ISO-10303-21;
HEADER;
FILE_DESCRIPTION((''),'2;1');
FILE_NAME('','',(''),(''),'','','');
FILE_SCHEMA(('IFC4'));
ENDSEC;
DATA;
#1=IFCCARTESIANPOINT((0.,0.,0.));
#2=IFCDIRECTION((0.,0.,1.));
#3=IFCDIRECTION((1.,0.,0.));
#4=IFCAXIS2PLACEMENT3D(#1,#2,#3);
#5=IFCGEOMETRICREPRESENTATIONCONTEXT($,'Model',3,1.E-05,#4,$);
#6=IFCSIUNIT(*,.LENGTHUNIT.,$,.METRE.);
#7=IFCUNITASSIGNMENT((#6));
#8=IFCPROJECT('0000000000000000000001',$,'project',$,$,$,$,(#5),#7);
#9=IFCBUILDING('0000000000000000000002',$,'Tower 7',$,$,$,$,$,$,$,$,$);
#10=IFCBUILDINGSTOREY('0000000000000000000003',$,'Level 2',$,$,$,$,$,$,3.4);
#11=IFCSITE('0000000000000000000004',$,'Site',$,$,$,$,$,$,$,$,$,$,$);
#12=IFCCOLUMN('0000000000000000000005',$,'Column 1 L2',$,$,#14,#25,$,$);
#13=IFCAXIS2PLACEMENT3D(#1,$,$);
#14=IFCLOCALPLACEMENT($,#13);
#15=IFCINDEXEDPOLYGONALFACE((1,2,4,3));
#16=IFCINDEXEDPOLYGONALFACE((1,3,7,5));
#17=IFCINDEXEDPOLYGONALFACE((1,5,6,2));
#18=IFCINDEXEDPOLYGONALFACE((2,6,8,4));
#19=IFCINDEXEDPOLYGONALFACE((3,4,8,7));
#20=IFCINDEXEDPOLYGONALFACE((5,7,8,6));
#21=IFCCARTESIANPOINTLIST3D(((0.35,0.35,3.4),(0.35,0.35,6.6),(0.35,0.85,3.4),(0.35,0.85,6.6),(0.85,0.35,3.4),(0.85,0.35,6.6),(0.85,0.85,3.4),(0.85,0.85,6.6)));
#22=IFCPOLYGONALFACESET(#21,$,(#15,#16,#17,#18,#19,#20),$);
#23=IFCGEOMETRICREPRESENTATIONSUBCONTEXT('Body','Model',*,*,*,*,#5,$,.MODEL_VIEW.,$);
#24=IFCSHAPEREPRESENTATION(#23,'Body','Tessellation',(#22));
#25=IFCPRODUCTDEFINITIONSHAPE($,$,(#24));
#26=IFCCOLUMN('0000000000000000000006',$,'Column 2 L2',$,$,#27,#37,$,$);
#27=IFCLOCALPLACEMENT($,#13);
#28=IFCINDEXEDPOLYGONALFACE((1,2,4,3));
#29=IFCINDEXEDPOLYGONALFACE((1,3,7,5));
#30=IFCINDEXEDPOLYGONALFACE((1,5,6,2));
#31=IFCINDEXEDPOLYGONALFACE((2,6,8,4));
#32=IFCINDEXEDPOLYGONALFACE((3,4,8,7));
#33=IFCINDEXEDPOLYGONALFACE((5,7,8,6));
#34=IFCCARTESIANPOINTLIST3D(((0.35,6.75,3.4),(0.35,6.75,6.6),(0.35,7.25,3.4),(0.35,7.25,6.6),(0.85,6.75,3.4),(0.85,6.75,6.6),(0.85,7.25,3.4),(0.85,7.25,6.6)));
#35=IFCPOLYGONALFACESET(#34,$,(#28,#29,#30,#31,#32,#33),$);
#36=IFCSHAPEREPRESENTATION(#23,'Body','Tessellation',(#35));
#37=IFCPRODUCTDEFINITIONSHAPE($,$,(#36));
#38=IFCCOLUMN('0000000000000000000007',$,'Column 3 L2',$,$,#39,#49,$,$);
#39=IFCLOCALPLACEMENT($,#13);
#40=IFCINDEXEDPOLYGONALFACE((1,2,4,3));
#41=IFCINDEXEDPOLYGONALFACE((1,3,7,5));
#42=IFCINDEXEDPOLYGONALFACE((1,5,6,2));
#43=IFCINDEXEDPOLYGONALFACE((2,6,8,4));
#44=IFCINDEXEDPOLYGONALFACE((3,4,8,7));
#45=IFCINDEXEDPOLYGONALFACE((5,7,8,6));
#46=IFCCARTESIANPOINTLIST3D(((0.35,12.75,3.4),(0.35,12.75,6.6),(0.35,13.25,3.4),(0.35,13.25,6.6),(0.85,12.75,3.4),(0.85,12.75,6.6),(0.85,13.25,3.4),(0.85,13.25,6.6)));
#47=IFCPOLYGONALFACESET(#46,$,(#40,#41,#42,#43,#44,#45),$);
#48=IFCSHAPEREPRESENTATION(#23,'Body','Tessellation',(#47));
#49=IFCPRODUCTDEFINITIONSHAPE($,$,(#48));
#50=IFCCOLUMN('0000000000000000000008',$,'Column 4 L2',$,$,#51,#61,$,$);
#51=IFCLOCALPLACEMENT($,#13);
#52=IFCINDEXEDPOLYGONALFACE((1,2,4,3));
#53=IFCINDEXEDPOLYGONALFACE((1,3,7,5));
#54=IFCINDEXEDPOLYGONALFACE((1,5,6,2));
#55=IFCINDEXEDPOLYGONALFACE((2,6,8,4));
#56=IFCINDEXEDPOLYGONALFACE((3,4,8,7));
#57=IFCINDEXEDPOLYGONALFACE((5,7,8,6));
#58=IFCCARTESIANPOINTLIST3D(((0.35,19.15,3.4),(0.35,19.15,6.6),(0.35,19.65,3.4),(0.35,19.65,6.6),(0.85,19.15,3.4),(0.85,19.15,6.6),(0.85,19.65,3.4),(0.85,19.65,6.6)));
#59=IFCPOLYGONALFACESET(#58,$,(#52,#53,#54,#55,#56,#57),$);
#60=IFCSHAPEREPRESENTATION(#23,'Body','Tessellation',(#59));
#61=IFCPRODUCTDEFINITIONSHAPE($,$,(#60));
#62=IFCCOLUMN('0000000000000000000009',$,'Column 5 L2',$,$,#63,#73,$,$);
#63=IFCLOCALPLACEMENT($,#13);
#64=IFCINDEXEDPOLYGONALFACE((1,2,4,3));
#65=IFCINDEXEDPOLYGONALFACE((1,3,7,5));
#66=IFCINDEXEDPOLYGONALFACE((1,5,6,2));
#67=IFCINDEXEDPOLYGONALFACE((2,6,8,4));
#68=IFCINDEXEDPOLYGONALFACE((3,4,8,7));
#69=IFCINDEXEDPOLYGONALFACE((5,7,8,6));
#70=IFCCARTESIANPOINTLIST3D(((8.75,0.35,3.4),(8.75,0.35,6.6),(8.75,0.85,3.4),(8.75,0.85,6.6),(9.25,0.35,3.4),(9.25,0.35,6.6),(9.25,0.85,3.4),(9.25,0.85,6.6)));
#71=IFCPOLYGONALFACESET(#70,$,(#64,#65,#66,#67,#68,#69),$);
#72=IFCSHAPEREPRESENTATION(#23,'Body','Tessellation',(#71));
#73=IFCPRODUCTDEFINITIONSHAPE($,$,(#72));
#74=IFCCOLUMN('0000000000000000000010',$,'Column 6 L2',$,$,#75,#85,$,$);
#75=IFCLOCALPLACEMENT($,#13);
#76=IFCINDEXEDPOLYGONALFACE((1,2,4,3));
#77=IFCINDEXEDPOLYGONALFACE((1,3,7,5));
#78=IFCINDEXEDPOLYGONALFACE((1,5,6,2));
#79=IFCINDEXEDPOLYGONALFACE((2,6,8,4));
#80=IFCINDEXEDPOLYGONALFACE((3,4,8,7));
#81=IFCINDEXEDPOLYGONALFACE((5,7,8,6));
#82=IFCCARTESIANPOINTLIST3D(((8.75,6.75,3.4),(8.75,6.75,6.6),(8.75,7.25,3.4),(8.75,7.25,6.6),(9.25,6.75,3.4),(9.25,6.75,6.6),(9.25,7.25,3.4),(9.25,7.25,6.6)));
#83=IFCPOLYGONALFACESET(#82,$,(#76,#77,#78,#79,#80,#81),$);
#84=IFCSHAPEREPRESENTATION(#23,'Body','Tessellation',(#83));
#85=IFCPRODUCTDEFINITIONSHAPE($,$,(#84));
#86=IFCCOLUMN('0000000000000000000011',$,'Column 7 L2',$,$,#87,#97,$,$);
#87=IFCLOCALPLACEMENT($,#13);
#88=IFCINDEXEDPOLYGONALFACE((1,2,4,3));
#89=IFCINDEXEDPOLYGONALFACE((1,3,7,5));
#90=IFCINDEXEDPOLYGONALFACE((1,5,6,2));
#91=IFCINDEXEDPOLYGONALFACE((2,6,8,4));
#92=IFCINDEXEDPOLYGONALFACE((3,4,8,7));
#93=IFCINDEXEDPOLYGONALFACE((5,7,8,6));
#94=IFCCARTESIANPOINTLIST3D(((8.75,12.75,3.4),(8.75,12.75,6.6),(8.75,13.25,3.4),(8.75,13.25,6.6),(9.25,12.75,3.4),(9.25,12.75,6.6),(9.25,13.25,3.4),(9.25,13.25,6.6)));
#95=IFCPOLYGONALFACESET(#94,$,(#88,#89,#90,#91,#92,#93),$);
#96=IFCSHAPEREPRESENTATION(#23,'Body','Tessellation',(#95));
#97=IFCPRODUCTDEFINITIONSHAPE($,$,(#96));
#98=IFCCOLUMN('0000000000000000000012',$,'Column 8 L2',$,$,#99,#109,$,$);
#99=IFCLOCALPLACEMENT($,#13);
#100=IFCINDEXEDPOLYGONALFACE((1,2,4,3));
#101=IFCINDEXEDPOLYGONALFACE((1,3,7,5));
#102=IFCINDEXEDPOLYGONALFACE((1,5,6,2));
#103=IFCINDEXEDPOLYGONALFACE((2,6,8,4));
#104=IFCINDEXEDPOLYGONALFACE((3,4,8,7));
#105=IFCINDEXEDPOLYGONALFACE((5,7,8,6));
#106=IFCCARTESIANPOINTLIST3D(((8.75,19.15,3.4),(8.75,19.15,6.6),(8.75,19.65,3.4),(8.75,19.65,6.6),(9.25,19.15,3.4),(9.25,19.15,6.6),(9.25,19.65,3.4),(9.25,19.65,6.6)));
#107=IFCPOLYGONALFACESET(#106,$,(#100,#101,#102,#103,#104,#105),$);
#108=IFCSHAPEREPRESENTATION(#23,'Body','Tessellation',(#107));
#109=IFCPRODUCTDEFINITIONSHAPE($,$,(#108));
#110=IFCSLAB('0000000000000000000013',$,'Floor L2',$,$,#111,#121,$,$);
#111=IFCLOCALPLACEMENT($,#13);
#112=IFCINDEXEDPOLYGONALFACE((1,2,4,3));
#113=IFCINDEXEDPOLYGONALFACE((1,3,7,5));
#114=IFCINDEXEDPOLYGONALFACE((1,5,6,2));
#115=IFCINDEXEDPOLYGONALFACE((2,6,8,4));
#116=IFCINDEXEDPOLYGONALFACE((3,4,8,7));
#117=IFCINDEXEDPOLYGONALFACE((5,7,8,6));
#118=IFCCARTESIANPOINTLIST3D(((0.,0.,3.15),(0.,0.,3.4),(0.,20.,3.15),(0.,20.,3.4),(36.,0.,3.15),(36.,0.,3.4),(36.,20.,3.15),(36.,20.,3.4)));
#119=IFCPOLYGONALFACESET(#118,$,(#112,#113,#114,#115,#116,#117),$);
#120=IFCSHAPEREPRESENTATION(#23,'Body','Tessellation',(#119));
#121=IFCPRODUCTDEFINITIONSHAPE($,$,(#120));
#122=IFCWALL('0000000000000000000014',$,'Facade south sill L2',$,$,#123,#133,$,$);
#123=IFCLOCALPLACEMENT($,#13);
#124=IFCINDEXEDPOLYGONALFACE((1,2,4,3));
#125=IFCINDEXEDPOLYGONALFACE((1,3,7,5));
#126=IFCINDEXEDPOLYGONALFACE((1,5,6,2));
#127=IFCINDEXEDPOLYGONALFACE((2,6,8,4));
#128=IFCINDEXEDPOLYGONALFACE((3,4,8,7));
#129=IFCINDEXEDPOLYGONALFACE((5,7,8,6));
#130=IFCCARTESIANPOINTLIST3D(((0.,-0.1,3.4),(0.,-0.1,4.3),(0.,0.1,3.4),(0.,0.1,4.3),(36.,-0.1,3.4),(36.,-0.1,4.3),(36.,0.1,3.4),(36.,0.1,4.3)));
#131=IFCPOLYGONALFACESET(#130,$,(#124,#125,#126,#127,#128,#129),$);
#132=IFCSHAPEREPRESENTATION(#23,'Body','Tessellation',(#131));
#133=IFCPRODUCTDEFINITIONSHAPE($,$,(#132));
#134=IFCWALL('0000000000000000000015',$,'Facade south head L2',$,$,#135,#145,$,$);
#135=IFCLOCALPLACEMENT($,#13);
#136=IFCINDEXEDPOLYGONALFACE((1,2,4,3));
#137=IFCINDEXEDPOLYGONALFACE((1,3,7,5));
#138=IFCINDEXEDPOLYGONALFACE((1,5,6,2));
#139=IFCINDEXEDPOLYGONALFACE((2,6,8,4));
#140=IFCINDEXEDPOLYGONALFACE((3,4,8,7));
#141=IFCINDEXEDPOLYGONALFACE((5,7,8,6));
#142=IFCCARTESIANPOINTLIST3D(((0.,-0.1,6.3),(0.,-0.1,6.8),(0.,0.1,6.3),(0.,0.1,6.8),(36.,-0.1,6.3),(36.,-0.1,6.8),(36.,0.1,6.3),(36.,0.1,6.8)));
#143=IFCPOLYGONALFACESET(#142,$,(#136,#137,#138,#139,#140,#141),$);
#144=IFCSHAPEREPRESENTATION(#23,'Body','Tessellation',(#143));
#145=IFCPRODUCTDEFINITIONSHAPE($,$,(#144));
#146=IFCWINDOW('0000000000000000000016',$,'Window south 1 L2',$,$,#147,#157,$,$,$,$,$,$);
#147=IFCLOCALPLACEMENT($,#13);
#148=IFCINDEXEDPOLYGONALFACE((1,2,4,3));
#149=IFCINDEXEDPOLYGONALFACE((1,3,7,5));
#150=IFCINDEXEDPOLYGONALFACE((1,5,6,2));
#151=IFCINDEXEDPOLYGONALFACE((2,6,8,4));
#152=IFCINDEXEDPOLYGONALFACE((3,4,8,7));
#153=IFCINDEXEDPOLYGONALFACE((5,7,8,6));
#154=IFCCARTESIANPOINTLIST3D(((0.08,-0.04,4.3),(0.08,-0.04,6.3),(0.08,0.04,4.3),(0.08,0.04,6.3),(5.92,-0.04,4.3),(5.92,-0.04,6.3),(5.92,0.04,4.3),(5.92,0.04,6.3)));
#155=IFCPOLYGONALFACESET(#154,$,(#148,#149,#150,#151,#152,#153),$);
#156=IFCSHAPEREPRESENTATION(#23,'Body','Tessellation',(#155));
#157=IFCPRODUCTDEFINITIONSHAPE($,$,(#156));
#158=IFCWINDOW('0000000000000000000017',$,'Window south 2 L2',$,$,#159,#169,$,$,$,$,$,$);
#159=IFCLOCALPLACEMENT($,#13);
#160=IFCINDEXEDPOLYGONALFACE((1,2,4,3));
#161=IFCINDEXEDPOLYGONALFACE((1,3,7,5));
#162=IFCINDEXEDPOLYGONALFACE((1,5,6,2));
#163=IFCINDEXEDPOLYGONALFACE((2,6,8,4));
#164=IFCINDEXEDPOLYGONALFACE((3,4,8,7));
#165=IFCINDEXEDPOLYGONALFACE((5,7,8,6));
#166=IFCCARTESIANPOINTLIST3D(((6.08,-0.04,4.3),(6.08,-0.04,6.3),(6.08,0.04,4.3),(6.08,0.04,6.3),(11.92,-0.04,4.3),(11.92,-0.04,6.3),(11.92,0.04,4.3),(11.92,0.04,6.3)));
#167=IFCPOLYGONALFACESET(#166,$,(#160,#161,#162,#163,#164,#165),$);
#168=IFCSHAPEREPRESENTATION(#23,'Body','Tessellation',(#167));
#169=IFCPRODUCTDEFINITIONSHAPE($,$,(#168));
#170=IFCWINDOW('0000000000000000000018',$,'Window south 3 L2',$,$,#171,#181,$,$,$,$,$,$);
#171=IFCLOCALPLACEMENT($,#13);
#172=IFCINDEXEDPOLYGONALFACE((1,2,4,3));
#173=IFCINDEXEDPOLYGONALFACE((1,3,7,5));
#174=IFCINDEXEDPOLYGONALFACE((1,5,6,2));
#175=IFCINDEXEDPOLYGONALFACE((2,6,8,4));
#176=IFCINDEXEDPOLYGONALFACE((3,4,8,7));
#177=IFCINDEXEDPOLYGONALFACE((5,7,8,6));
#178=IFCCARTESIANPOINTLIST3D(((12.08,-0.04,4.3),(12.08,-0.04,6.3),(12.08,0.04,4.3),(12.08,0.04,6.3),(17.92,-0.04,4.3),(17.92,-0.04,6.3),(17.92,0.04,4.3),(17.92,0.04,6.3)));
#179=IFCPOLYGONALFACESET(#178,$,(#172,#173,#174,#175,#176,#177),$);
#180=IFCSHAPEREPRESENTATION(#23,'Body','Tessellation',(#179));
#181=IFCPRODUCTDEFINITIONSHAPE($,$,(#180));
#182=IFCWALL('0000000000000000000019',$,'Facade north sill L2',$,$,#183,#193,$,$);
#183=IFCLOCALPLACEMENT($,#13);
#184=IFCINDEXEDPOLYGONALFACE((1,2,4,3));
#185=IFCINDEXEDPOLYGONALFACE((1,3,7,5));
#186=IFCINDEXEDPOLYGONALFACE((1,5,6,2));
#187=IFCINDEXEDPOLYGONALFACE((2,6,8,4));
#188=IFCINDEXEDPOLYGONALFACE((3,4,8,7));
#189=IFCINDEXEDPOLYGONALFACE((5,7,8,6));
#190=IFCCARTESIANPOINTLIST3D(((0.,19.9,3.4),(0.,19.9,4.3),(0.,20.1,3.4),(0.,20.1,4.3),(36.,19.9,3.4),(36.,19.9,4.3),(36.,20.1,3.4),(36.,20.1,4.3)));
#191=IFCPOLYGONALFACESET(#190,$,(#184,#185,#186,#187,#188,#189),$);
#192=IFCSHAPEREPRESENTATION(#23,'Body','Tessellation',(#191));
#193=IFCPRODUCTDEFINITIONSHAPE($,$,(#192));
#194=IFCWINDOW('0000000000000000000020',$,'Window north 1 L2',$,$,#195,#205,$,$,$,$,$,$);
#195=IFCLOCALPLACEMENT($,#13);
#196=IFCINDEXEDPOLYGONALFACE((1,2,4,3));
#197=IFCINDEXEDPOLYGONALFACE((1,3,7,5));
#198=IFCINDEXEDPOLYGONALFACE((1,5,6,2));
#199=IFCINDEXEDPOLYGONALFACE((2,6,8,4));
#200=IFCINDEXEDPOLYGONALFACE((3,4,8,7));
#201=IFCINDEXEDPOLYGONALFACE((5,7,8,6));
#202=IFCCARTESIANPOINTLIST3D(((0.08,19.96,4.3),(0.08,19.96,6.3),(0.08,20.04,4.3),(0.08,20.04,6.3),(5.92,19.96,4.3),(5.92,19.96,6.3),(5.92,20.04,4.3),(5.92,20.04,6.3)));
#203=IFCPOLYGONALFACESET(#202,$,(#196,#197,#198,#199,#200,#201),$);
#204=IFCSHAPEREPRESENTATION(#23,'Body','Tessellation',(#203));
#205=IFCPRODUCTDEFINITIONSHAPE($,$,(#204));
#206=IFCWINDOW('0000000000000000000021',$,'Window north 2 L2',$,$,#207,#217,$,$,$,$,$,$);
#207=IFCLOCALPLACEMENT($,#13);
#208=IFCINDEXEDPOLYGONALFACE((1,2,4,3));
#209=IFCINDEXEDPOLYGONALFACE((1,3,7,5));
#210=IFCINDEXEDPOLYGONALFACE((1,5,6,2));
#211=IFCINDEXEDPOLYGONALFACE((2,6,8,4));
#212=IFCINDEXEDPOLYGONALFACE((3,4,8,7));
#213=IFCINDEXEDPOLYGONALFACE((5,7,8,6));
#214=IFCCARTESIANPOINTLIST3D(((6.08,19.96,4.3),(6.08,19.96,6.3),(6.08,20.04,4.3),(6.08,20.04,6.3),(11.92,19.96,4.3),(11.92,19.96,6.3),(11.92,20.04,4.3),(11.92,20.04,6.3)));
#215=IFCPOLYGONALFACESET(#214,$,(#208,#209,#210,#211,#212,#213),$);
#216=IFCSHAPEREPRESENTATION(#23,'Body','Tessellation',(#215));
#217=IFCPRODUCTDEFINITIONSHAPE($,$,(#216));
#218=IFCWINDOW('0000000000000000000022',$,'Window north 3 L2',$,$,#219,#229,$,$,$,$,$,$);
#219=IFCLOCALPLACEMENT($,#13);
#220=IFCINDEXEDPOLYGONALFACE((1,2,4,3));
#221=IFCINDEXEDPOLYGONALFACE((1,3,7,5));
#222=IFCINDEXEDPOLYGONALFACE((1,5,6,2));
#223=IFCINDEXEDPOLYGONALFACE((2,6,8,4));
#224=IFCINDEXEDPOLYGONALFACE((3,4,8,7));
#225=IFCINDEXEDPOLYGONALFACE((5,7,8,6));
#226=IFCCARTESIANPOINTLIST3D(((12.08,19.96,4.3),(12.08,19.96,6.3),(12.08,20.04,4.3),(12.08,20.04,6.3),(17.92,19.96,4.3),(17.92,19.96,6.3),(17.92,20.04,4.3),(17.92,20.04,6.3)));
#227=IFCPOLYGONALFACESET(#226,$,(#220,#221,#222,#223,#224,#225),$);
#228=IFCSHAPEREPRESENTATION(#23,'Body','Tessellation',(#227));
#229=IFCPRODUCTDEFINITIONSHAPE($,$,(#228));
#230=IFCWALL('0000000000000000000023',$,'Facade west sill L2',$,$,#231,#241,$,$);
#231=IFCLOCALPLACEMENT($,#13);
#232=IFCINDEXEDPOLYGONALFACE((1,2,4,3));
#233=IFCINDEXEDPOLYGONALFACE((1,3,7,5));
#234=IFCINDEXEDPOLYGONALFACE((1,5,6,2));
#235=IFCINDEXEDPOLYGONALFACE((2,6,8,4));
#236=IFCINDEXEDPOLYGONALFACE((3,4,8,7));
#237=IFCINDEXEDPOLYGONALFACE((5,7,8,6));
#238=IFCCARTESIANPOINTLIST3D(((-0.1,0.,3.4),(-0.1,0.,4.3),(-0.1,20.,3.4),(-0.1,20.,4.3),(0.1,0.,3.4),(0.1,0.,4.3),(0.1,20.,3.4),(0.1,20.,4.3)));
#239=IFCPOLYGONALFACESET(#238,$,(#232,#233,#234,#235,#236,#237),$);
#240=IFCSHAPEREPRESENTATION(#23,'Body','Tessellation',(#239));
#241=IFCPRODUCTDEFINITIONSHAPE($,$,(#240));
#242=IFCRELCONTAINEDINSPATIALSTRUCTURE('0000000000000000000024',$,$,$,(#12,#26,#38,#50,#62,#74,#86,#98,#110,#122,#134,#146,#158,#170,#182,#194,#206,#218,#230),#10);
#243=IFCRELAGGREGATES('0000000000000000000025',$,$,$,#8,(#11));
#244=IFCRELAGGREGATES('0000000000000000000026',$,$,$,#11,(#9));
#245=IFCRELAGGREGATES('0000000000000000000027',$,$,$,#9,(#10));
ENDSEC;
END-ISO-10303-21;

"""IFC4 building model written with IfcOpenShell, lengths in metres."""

from ifc_helpers import new_model, si_unit, frame, origin, origin_with_axes, origin_2d, place, context, subcontext, project, spatial, rectangle, extrude, element, save


model = new_model("IFC4")

# Units and contexts
model_context = context("Model", 3, precision=1e-05, world=origin_with_axes())
body_context = subcontext(model_context, "Body", "Model", "MODEL_VIEW")
ifc_project = project(units=[si_unit("LENGTHUNIT", "METRE")], contexts=[model_context])

# Site, building, storey
site = spatial("IfcSite", under=ifc_project, Name="Site")
building = spatial("IfcBuilding", under=site, Name="Tower 7")
storey = spatial("IfcBuildingStorey", under=building, Name="Level 2", Elevation=3.4)

# Columns
for number, where, z_axis, x_axis, name in (
    (1, (0.6, 0.6, 3.4), (0.0, 0.0, 1.0), (1.0, 0.0, 0.0), "Column 1 L2"),
    (2, (0.6, 7.0, 3.4), (0.0, 0.0, 1.0), (1.0, 0.0, 0.0), "Column 2 L2"),
    (3, (0.6, 13.0, 3.4), (0.0, 0.0, 1.0), (1.0, 0.0, 0.0), "Column 3 L2"),
    (4, (0.6, 19.4, 3.4), (0.0, 0.0, 1.0), (1.0, 0.0, 0.0), "Column 4 L2"),
    (5, (9.0, 0.6, 3.4), (0.0, 0.0, 1.0), (1.0, 0.0, 0.0), "Column 5 L2"),
    (6, (9.0, 7.0, 3.4), (0.0, 0.0, 1.0), (1.0, 0.0, 0.0), "Column 6 L2"),
    (7, (9.0, 13.0, 3.4), (0.0, 0.0, 1.0), (1.0, 0.0, 0.0), "Column 7 L2"),
    (8, (9.0, 19.4, 3.4), (0.0, 0.0, 1.0), (1.0, 0.0, 0.0), "Column 8 L2"),
):
    element("IfcColumn", number, at=place(None, frame(where, z_axis=z_axis, x_axis=x_axis)), inside=storey, Name=name, context=body_context, shape_type="SweptSolid", body=[
        extrude(rectangle(XDim=0.5, YDim=0.5, at=origin_2d()), origin(), (0.0, 0.0, 1.0), 3.2),
    ])

# Slab
slab_placement = place(None, frame((18.0, 10.0, 3.15), z_axis=(0.0, 0.0, 1.0), x_axis=(1.0, 0.0, 0.0)))
element("IfcSlab", 9, at=slab_placement, inside=storey, Name="Floor L2", context=body_context, shape_type="SweptSolid", body=[
    extrude(rectangle(XDim=36.0, YDim=20.0, at=origin_2d()), origin(), (0.0, 0.0, 1.0), 0.25),
])

# Walls
wall_1_placement = place(None, frame((18.0, 0.0, 3.4), z_axis=(0.0, 0.0, 1.0), x_axis=(1.0, 0.0, 0.0)))
element("IfcWall", 10, at=wall_1_placement, inside=storey, Name="Facade south sill L2", context=body_context, shape_type="SweptSolid", body=[
    extrude(rectangle(XDim=36.0, YDim=0.2, at=origin_2d()), origin(), (0.0, 0.0, 1.0), 0.9),
])
wall_2_placement = place(None, frame((18.0, 0.0, 6.3), z_axis=(0.0, 0.0, 1.0), x_axis=(1.0, 0.0, 0.0)))
element("IfcWall", 11, at=wall_2_placement, inside=storey, Name="Facade south head L2", context=body_context, shape_type="SweptSolid", body=[
    extrude(rectangle(XDim=36.0, YDim=0.2, at=origin_2d()), origin(), (0.0, 0.0, 1.0), 0.5),
])

# Windows
for number, where, z_axis, x_axis, name in (
    (12, (3.0, 0.0, 4.3), (0.0, 0.0, 1.0), (1.0, 0.0, 0.0), "Window south 1 L2"),
    (13, (9.0, 0.0, 4.3), (0.0, 0.0, 1.0), (1.0, 0.0, 0.0), "Window south 2 L2"),
):
    element("IfcWindow", number, at=place(None, frame(where, z_axis=z_axis, x_axis=x_axis)), inside=storey, Name=name, context=body_context, shape_type="SweptSolid", body=[
        extrude(rectangle(XDim=5.84, YDim=0.08, at=origin_2d()), origin(), (0.0, 0.0, 1.0), 2.0),
    ])
window_1_placement = place(None, frame((15.0, 0.0, 4.3), z_axis=(0.0, 0.0, 1.0), x_axis=(1.0, 0.0, 0.0)))
element("IfcWindow", 14, at=window_1_placement, inside=storey, Name="Window south 3 L2", context=body_context, shape_type="SweptSolid", body=[
    extrude(rectangle(XDim=5.84, YDim=0.08, at=origin_2d()), origin(), (0.0, 0.0, 1.0), 2.0),
])

# Wall
wall_3_placement = place(None, frame((18.0, 20.0, 3.4), z_axis=(0.0, 0.0, 1.0), x_axis=(1.0, 0.0, 0.0)))
element("IfcWall", 15, at=wall_3_placement, inside=storey, Name="Facade north sill L2", context=body_context, shape_type="SweptSolid", body=[
    extrude(rectangle(XDim=36.0, YDim=0.2, at=origin_2d()), origin(), (0.0, 0.0, 1.0), 0.9),
])

# Windows
for number, where, z_axis, x_axis, name in (
    (16, (3.0, 20.0, 4.3), (0.0, 0.0, 1.0), (1.0, 0.0, 0.0), "Window north 1 L2"),
    (17, (9.0, 20.0, 4.3), (0.0, 0.0, 1.0), (1.0, 0.0, 0.0), "Window north 2 L2"),
):
    element("IfcWindow", number, at=place(None, frame(where, z_axis=z_axis, x_axis=x_axis)), inside=storey, Name=name, context=body_context, shape_type="SweptSolid", body=[
        extrude(rectangle(XDim=5.84, YDim=0.08, at=origin_2d()), origin(), (0.0, 0.0, 1.0), 2.0),
    ])
window_2_placement = place(None, frame((15.0, 20.0, 4.3), z_axis=(0.0, 0.0, 1.0), x_axis=(1.0, 0.0, 0.0)))
element("IfcWindow", 18, at=window_2_placement, inside=storey, Name="Window north 3 L2", context=body_context, shape_type="SweptSolid", body=[
    extrude(rectangle(XDim=5.84, YDim=0.08, at=origin_2d()), origin(), (0.0, 0.0, 1.0), 2.0),
])

# Wall
wall_4_placement = place(None, frame((0.0, 10.0, 3.4), z_axis=(0.0, 0.0, 1.0), x_axis=(1.0, 0.0, 0.0)))
element("IfcWall", 19, at=wall_4_placement, inside=storey, Name="Facade west sill L2", context=body_context, shape_type="SweptSolid", body=[
    extrude(rectangle(XDim=0.2, YDim=20.0, at=origin_2d()), origin(), (0.0, 0.0, 1.0), 0.9),
])

save(model, "model.ifc")
